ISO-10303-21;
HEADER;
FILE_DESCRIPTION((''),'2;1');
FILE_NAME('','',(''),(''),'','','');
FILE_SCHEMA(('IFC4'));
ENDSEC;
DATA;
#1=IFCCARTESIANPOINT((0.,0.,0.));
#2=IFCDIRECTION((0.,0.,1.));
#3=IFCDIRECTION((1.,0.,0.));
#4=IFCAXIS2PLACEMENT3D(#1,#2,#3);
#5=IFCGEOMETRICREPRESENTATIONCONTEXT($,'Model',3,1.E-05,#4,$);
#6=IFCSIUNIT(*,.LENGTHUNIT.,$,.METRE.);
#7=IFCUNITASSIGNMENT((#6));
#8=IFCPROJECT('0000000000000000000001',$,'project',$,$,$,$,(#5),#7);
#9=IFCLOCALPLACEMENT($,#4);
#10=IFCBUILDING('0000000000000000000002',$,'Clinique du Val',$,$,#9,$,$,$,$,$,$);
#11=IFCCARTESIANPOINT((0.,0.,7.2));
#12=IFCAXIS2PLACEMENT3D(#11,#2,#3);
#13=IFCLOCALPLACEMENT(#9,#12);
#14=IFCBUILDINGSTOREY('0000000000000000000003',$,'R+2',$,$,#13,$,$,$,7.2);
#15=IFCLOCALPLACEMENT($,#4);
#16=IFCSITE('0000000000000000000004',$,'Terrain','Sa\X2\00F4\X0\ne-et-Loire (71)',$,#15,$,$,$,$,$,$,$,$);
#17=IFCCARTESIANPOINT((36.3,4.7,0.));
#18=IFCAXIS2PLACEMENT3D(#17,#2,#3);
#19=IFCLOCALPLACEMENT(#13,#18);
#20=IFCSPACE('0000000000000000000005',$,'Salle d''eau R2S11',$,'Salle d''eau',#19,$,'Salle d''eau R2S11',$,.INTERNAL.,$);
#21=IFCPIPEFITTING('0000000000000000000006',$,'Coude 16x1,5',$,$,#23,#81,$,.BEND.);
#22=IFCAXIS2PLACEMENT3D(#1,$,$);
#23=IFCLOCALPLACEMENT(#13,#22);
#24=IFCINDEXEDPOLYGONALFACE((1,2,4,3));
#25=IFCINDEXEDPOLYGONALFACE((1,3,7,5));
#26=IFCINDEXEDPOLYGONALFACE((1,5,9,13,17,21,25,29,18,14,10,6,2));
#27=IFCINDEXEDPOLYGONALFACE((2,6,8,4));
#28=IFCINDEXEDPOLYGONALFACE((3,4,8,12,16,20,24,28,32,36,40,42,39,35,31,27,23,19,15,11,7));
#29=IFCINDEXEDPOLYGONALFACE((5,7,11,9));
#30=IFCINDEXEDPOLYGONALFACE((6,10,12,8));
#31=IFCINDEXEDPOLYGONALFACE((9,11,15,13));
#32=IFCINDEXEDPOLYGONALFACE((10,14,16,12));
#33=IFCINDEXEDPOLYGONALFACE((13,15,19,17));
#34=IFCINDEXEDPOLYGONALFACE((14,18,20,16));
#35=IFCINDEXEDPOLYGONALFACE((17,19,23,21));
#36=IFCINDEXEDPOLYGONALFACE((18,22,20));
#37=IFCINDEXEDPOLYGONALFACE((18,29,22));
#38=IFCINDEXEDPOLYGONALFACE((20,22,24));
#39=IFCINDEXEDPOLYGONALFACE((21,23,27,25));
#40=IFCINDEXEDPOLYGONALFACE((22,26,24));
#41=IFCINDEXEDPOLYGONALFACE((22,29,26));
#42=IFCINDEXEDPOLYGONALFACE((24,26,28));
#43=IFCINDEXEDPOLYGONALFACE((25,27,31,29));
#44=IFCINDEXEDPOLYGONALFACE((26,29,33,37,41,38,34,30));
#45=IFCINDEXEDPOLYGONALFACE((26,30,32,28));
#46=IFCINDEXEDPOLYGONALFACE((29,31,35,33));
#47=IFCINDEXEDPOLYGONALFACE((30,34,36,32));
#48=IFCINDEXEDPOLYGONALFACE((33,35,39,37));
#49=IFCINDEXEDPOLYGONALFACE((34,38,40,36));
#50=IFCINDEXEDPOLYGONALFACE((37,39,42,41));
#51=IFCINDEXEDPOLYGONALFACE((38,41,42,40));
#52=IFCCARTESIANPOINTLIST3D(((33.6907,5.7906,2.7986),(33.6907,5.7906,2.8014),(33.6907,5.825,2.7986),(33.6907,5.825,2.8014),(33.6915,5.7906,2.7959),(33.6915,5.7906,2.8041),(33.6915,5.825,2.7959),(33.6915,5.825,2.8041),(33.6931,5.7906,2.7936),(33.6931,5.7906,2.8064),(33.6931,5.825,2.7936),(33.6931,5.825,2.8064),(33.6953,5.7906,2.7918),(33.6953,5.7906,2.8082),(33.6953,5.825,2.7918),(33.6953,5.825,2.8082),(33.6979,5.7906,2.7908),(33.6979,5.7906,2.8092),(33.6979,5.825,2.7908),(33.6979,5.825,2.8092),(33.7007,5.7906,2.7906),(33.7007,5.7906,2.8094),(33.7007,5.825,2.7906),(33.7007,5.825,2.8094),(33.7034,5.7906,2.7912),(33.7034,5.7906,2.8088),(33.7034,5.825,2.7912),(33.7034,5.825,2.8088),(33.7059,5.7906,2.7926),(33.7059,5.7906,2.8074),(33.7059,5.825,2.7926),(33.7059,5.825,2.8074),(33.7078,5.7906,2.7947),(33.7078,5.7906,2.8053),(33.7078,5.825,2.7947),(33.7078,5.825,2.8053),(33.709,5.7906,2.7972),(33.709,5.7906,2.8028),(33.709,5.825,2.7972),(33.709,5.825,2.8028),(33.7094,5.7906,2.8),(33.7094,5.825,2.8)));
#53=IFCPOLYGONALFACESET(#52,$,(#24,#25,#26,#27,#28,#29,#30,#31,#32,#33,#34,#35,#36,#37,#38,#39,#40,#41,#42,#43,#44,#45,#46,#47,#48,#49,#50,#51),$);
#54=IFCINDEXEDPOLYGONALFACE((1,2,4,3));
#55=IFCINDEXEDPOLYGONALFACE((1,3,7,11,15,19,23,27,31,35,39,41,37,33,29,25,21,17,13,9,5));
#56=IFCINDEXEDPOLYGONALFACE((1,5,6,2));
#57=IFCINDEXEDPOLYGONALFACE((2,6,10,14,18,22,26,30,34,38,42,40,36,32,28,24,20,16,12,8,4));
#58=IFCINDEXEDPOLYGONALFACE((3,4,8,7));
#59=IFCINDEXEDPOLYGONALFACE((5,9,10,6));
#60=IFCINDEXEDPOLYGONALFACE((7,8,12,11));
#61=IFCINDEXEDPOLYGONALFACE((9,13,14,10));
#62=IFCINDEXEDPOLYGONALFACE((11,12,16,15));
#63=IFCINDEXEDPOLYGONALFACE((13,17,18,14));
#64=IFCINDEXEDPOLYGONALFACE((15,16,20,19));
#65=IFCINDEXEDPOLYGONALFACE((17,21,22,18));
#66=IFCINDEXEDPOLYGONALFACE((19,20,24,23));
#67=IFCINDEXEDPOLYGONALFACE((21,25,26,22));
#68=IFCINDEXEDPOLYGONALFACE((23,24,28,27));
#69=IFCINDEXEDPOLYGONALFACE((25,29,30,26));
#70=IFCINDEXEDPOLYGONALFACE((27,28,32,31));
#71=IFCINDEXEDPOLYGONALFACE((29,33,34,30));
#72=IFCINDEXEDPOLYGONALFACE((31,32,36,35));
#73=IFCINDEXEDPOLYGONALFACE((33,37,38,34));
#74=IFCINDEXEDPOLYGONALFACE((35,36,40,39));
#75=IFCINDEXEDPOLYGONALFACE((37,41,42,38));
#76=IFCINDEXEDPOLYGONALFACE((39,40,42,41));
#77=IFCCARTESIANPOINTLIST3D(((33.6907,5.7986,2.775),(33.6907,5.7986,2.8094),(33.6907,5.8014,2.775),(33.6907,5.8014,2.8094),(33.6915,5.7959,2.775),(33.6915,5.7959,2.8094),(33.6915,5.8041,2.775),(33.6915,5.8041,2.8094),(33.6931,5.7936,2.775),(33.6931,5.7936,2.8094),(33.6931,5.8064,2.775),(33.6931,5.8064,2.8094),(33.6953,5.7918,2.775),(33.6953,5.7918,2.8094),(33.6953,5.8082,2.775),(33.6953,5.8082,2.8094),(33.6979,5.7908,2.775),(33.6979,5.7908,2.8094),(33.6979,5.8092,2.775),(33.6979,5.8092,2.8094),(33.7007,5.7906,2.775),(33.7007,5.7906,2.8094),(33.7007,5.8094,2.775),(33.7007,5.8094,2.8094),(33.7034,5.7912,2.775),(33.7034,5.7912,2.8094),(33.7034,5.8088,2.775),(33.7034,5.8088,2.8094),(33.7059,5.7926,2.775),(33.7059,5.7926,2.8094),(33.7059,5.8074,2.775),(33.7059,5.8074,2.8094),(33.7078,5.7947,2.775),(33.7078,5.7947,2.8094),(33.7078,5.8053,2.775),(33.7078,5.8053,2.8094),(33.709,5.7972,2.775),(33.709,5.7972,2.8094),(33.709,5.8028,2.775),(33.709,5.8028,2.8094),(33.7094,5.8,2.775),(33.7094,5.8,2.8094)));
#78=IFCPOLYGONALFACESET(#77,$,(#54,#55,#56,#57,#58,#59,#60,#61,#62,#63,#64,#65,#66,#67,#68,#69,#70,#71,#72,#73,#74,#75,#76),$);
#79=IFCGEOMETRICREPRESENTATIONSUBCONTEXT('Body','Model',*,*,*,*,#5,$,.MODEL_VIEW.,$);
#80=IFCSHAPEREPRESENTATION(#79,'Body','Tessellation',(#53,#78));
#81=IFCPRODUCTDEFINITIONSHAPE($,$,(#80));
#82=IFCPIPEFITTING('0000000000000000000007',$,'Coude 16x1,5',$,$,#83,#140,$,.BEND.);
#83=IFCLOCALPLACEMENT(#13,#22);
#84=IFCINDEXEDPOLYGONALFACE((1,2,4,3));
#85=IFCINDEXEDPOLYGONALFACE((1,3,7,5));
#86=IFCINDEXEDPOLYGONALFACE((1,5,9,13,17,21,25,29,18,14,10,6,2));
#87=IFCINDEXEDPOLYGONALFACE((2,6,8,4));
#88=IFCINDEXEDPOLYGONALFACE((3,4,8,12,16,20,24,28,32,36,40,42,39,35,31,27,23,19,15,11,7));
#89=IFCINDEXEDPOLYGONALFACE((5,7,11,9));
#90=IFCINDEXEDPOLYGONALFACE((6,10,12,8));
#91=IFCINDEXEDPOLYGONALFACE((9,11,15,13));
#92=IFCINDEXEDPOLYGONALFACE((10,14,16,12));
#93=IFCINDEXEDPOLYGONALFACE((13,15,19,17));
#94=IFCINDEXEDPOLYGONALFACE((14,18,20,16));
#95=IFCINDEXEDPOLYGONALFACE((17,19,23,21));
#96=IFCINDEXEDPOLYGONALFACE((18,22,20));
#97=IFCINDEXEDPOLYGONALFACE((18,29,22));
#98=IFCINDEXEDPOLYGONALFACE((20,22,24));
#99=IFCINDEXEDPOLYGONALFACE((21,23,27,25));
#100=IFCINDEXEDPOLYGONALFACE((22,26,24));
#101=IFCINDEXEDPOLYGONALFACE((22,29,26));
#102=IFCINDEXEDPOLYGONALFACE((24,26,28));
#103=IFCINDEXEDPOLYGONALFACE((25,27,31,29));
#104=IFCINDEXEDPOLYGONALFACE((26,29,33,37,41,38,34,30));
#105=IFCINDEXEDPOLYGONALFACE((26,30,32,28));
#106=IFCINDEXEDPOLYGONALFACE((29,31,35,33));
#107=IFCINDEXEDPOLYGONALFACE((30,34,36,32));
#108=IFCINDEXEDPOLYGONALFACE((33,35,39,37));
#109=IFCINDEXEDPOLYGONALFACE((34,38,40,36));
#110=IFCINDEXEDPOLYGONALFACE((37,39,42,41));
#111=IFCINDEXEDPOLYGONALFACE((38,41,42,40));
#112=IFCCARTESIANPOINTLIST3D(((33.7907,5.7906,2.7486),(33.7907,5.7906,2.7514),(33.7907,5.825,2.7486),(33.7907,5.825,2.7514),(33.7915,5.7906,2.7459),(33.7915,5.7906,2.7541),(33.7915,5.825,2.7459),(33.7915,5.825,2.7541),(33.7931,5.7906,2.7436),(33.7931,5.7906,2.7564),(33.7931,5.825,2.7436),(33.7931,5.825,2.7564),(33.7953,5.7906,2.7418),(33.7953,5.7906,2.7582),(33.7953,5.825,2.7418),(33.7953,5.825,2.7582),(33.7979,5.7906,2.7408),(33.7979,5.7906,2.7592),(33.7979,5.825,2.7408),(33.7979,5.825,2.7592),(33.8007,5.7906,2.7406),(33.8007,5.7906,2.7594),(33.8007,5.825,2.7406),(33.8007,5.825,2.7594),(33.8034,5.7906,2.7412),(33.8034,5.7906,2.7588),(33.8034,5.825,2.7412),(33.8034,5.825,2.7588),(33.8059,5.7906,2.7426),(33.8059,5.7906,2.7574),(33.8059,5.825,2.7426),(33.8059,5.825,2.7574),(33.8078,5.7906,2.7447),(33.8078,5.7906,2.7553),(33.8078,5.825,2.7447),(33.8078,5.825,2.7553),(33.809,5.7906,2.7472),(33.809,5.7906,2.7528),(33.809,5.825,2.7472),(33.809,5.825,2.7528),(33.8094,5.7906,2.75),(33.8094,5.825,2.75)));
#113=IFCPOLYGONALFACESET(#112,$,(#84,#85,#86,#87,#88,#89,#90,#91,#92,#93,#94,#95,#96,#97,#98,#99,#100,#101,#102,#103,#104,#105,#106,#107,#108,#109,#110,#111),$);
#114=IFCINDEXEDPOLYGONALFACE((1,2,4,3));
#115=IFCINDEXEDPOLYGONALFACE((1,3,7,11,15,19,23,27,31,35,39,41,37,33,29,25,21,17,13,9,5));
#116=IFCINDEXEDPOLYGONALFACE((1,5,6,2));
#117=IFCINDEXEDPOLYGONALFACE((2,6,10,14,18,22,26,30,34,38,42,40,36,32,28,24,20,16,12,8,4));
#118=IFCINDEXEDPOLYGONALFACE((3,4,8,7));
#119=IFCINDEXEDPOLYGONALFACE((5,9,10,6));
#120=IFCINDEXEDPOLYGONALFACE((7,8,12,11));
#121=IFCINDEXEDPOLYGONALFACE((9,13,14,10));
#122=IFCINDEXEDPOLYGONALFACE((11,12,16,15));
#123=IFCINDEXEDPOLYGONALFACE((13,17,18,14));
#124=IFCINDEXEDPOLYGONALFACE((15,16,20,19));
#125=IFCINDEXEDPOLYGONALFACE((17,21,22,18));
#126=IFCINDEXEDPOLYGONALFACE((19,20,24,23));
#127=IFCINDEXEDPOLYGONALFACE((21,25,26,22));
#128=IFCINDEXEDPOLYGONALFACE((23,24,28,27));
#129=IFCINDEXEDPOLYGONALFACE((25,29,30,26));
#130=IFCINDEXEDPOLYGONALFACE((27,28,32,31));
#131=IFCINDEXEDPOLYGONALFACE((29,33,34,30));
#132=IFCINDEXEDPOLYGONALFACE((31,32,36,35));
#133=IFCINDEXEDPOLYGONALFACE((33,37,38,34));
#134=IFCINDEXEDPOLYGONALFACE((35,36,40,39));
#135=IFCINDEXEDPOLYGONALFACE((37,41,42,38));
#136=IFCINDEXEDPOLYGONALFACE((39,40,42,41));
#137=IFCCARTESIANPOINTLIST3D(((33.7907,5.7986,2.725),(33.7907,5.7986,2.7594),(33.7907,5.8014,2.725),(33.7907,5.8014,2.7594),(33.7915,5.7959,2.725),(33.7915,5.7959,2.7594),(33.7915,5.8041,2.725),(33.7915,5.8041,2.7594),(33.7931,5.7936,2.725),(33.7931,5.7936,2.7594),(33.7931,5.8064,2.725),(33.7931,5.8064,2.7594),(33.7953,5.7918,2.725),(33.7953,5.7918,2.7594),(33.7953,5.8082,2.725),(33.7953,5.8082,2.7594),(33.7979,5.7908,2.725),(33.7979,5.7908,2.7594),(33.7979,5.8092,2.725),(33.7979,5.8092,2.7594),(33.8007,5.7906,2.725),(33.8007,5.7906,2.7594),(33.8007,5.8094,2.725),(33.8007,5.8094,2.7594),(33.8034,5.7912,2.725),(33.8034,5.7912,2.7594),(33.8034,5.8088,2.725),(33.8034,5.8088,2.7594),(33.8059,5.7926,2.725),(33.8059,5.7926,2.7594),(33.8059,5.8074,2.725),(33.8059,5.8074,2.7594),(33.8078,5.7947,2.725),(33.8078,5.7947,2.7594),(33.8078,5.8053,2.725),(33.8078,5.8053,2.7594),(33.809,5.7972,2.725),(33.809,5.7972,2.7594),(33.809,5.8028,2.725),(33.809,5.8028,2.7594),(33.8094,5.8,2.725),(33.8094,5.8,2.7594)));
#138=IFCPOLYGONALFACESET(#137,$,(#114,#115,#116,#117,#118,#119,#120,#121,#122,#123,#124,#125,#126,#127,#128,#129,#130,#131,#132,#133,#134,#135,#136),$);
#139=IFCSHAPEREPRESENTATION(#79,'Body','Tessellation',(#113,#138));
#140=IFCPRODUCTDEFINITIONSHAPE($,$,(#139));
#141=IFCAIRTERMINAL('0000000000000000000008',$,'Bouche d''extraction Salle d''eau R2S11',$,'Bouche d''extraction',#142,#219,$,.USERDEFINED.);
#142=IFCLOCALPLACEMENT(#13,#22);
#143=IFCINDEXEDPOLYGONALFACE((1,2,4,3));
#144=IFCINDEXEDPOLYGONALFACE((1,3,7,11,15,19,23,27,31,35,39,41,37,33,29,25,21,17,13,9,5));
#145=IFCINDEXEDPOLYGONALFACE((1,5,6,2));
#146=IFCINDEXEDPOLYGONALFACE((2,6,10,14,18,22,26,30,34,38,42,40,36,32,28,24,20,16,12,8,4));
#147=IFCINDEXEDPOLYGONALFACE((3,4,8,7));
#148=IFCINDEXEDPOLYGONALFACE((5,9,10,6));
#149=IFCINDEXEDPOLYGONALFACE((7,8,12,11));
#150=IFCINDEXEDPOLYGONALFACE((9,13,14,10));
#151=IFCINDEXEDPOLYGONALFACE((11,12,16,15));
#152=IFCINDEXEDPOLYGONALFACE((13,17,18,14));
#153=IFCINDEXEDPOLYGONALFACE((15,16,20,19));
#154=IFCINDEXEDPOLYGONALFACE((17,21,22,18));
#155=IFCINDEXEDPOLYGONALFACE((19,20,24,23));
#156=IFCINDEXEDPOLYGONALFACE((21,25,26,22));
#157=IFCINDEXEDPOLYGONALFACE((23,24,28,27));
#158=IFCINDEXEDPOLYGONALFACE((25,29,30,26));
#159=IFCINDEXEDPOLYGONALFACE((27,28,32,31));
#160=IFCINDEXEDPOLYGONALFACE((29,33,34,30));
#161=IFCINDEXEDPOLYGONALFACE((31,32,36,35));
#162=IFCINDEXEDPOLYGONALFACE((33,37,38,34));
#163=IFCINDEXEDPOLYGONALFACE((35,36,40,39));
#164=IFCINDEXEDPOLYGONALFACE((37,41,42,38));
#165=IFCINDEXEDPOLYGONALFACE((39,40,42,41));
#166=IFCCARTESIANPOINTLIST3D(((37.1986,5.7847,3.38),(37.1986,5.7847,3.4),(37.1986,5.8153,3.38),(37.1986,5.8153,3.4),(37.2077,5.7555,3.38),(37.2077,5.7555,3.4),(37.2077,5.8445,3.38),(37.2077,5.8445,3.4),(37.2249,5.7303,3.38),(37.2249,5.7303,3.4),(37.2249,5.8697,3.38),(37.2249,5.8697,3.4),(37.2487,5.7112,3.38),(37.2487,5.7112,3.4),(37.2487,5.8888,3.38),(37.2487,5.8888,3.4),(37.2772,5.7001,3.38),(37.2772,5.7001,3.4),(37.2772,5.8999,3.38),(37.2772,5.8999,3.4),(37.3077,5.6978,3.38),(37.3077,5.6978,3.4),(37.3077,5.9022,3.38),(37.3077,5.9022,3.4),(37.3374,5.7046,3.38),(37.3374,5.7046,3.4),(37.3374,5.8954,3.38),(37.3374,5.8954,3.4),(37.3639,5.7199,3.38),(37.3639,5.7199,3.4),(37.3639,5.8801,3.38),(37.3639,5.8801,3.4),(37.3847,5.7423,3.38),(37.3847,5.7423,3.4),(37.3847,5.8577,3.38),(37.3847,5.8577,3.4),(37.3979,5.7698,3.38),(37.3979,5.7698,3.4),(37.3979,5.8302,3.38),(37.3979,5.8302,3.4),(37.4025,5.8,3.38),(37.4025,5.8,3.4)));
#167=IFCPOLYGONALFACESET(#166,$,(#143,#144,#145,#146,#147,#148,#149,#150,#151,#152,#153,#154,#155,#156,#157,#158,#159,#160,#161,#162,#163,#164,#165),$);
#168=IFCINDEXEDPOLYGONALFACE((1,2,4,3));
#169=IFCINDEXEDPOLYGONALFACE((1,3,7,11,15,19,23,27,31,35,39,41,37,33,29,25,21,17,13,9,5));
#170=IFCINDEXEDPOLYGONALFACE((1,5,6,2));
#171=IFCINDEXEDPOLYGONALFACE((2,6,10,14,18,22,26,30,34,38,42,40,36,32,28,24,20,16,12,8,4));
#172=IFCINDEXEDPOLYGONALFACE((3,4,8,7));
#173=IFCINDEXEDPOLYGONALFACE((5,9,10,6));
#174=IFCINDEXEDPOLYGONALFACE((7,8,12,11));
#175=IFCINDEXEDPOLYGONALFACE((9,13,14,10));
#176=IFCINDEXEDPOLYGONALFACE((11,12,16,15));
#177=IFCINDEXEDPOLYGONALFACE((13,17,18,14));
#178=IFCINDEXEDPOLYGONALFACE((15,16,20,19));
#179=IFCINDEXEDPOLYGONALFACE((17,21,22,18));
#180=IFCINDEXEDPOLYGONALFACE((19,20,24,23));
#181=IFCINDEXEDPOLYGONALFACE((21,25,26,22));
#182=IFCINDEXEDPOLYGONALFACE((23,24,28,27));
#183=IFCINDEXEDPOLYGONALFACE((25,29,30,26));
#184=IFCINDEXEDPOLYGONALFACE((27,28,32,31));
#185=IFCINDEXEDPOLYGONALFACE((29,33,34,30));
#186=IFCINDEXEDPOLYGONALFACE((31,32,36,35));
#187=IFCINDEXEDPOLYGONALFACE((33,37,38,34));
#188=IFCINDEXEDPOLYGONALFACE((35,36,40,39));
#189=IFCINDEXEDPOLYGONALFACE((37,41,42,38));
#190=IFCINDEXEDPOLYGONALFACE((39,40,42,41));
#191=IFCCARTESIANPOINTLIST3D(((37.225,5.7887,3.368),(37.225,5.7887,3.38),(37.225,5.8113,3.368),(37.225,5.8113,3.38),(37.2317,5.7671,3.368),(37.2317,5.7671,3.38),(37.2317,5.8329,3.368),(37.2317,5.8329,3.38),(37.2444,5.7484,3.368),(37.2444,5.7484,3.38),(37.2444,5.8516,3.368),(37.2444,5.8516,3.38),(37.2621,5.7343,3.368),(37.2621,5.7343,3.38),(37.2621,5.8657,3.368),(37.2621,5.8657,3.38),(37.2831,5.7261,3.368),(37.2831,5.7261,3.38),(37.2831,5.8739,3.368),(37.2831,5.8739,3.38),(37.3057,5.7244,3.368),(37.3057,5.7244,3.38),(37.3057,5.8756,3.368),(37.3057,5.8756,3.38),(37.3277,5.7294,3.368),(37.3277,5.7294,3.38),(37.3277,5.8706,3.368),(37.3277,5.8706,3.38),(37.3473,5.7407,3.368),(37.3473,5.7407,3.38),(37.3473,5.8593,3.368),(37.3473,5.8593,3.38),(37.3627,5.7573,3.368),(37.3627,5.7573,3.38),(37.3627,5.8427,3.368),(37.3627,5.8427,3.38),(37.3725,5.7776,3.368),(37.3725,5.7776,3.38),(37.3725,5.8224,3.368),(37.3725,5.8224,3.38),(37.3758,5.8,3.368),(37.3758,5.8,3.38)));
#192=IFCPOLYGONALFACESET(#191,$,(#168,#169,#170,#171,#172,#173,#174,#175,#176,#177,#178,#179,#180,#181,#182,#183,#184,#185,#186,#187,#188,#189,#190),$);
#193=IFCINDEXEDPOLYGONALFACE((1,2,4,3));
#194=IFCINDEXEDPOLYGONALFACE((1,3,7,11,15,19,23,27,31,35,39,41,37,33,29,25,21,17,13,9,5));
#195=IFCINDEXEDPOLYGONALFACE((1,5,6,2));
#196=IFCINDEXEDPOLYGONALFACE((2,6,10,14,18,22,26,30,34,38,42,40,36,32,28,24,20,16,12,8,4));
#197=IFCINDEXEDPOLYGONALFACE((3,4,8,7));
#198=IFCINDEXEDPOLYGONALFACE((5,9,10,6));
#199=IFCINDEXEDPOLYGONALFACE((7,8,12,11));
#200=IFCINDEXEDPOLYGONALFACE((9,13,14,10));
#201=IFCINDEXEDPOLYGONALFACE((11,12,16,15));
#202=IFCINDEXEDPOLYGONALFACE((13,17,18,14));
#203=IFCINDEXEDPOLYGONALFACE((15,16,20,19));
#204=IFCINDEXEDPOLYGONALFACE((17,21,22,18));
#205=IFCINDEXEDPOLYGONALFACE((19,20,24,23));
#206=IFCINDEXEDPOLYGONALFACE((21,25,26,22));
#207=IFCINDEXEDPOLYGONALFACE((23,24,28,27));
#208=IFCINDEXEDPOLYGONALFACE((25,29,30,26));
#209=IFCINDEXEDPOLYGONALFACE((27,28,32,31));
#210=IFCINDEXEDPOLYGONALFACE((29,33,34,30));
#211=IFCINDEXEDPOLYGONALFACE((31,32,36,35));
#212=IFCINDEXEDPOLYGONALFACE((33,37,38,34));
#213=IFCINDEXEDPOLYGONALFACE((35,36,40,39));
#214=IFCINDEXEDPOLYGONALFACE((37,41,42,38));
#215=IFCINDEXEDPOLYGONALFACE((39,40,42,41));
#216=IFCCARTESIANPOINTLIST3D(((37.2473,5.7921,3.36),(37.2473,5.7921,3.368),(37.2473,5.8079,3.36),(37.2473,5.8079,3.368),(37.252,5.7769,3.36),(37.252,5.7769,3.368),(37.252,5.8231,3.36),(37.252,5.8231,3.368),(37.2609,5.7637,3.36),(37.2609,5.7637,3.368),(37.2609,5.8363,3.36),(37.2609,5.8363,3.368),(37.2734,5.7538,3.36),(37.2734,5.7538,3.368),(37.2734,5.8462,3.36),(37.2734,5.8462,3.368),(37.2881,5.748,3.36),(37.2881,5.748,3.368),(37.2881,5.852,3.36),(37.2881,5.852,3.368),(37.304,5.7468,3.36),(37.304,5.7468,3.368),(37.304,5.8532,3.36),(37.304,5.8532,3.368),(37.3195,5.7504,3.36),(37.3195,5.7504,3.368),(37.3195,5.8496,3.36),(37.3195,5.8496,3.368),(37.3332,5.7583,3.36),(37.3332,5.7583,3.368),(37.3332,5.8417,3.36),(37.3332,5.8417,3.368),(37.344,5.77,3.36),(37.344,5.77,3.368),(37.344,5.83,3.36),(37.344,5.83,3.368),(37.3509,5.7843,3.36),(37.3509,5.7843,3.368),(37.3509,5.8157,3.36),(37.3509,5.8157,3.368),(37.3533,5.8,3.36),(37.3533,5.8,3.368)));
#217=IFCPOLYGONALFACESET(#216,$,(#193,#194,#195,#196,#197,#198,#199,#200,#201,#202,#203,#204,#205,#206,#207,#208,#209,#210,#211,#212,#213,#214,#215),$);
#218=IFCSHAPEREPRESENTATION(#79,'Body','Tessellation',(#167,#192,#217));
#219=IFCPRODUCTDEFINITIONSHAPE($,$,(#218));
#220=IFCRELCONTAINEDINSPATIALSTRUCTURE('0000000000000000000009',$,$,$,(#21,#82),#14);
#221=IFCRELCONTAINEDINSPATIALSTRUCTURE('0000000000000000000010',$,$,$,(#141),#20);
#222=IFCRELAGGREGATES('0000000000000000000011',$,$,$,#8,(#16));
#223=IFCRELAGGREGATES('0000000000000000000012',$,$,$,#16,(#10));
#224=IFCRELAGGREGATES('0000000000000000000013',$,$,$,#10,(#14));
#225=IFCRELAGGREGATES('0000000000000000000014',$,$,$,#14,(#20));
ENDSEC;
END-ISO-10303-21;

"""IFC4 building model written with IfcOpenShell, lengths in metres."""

from ifc_helpers import new_model, si_unit, frame, origin_with_axes, place, context, subcontext, project, spatial, circle, extrude, element, save


model = new_model("IFC4")

# Units and contexts
model_context = context("Model", 3, precision=1e-05, world=origin_with_axes())
body_context = subcontext(model_context, "Body", "Model", "MODEL_VIEW")
ifc_project = project(units=[si_unit("LENGTHUNIT", "METRE")], contexts=[model_context])

# Site, building, storey
site_placement = place(None, origin_with_axes())
site = spatial("IfcSite", under=ifc_project, at=site_placement, Name="Terrain", Description="Saône-et-Loire (71)")
building_placement = place(None, origin_with_axes())
building = spatial("IfcBuilding", under=site, at=building_placement, Name="Clinique du Val")
storey_placement = place(building_placement, frame((0.0, 0.0, 7.2), z_axis=(0.0, 0.0, 1.0), x_axis=(1.0, 0.0, 0.0)))
storey = spatial("IfcBuildingStorey", under=building, at=storey_placement, Name="R+2", Elevation=7.2)

# Pipe fittings
for number, where, z_axis, x_axis, name in (
    (1, (33.7, 5.8, 2.8), (0.0, 0.0, 1.0), (1.0, 0.0, 0.0), "Coude 16x1,5"),
    (2, (33.8, 5.8, 2.75), (0.0, 0.0, 1.0), (1.0, 0.0, 0.0), "Coude 16x1,5"),
):
    element("IfcPipeFitting", number, at=place(storey_placement, frame(where, z_axis=z_axis, x_axis=x_axis)), inside=storey, Name=name, PredefinedType="BEND", context=body_context, shape_type="SweptSolid", body=[
        extrude(circle(Radius=0.0094), frame((0.0, -0.0094, 0.0), z_axis=(0.0, 1.0, 0.0), x_axis=(1.0, 0.0, 0.0)), (0.0, 0.0, 1.0), 0.0344),
        extrude(circle(Radius=0.0094), frame((0.0, 0.0, 0.0094), z_axis=(0.0, 0.0, -1.0), x_axis=(1.0, 0.0, 0.0)), (0.0, 0.0, 1.0), 0.0344),
    ])

# Shared definitions
space_1_placement = place(storey_placement, frame((36.3, 4.7, 0.0), z_axis=(0.0, 0.0, 1.0), x_axis=(1.0, 0.0, 0.0)))
space_1 = spatial("IfcSpace", under=storey, at=space_1_placement, Name="Salle d'eau R2S11", ObjectType="Salle d'eau", LongName="Salle d'eau R2S11", PredefinedType="INTERNAL")

# Air terminal
air_terminal_1_placement = place(space_1_placement, frame((1.0, 1.1, 3.36), z_axis=(0.0, 0.0, 1.0), x_axis=(1.0, 0.0, 0.0)))
element("IfcAirTerminal", 3, at=air_terminal_1_placement, inside=space_1, Name="Bouche d'extraction Salle d'eau R2S11", ObjectType="Bouche d'extraction", PredefinedType="USERDEFINED", context=body_context, shape_type="SweptSolid", body=[
    extrude(circle(Radius=0.1025), frame((0.0, 0.0, 0.02), z_axis=(0.0, 0.0, 1.0), x_axis=(1.0, 0.0, 0.0)), (0.0, 0.0, 1.0), 0.02),
    extrude(circle(Radius=0.0759), frame((0.0, 0.0, 0.008), z_axis=(0.0, 0.0, 1.0), x_axis=(1.0, 0.0, 0.0)), (0.0, 0.0, 1.0), 0.012),
    extrude(circle(Radius=0.0533), origin_with_axes(), (0.0, 0.0, 1.0), 0.008),
])

save(model, "model.ifc")
